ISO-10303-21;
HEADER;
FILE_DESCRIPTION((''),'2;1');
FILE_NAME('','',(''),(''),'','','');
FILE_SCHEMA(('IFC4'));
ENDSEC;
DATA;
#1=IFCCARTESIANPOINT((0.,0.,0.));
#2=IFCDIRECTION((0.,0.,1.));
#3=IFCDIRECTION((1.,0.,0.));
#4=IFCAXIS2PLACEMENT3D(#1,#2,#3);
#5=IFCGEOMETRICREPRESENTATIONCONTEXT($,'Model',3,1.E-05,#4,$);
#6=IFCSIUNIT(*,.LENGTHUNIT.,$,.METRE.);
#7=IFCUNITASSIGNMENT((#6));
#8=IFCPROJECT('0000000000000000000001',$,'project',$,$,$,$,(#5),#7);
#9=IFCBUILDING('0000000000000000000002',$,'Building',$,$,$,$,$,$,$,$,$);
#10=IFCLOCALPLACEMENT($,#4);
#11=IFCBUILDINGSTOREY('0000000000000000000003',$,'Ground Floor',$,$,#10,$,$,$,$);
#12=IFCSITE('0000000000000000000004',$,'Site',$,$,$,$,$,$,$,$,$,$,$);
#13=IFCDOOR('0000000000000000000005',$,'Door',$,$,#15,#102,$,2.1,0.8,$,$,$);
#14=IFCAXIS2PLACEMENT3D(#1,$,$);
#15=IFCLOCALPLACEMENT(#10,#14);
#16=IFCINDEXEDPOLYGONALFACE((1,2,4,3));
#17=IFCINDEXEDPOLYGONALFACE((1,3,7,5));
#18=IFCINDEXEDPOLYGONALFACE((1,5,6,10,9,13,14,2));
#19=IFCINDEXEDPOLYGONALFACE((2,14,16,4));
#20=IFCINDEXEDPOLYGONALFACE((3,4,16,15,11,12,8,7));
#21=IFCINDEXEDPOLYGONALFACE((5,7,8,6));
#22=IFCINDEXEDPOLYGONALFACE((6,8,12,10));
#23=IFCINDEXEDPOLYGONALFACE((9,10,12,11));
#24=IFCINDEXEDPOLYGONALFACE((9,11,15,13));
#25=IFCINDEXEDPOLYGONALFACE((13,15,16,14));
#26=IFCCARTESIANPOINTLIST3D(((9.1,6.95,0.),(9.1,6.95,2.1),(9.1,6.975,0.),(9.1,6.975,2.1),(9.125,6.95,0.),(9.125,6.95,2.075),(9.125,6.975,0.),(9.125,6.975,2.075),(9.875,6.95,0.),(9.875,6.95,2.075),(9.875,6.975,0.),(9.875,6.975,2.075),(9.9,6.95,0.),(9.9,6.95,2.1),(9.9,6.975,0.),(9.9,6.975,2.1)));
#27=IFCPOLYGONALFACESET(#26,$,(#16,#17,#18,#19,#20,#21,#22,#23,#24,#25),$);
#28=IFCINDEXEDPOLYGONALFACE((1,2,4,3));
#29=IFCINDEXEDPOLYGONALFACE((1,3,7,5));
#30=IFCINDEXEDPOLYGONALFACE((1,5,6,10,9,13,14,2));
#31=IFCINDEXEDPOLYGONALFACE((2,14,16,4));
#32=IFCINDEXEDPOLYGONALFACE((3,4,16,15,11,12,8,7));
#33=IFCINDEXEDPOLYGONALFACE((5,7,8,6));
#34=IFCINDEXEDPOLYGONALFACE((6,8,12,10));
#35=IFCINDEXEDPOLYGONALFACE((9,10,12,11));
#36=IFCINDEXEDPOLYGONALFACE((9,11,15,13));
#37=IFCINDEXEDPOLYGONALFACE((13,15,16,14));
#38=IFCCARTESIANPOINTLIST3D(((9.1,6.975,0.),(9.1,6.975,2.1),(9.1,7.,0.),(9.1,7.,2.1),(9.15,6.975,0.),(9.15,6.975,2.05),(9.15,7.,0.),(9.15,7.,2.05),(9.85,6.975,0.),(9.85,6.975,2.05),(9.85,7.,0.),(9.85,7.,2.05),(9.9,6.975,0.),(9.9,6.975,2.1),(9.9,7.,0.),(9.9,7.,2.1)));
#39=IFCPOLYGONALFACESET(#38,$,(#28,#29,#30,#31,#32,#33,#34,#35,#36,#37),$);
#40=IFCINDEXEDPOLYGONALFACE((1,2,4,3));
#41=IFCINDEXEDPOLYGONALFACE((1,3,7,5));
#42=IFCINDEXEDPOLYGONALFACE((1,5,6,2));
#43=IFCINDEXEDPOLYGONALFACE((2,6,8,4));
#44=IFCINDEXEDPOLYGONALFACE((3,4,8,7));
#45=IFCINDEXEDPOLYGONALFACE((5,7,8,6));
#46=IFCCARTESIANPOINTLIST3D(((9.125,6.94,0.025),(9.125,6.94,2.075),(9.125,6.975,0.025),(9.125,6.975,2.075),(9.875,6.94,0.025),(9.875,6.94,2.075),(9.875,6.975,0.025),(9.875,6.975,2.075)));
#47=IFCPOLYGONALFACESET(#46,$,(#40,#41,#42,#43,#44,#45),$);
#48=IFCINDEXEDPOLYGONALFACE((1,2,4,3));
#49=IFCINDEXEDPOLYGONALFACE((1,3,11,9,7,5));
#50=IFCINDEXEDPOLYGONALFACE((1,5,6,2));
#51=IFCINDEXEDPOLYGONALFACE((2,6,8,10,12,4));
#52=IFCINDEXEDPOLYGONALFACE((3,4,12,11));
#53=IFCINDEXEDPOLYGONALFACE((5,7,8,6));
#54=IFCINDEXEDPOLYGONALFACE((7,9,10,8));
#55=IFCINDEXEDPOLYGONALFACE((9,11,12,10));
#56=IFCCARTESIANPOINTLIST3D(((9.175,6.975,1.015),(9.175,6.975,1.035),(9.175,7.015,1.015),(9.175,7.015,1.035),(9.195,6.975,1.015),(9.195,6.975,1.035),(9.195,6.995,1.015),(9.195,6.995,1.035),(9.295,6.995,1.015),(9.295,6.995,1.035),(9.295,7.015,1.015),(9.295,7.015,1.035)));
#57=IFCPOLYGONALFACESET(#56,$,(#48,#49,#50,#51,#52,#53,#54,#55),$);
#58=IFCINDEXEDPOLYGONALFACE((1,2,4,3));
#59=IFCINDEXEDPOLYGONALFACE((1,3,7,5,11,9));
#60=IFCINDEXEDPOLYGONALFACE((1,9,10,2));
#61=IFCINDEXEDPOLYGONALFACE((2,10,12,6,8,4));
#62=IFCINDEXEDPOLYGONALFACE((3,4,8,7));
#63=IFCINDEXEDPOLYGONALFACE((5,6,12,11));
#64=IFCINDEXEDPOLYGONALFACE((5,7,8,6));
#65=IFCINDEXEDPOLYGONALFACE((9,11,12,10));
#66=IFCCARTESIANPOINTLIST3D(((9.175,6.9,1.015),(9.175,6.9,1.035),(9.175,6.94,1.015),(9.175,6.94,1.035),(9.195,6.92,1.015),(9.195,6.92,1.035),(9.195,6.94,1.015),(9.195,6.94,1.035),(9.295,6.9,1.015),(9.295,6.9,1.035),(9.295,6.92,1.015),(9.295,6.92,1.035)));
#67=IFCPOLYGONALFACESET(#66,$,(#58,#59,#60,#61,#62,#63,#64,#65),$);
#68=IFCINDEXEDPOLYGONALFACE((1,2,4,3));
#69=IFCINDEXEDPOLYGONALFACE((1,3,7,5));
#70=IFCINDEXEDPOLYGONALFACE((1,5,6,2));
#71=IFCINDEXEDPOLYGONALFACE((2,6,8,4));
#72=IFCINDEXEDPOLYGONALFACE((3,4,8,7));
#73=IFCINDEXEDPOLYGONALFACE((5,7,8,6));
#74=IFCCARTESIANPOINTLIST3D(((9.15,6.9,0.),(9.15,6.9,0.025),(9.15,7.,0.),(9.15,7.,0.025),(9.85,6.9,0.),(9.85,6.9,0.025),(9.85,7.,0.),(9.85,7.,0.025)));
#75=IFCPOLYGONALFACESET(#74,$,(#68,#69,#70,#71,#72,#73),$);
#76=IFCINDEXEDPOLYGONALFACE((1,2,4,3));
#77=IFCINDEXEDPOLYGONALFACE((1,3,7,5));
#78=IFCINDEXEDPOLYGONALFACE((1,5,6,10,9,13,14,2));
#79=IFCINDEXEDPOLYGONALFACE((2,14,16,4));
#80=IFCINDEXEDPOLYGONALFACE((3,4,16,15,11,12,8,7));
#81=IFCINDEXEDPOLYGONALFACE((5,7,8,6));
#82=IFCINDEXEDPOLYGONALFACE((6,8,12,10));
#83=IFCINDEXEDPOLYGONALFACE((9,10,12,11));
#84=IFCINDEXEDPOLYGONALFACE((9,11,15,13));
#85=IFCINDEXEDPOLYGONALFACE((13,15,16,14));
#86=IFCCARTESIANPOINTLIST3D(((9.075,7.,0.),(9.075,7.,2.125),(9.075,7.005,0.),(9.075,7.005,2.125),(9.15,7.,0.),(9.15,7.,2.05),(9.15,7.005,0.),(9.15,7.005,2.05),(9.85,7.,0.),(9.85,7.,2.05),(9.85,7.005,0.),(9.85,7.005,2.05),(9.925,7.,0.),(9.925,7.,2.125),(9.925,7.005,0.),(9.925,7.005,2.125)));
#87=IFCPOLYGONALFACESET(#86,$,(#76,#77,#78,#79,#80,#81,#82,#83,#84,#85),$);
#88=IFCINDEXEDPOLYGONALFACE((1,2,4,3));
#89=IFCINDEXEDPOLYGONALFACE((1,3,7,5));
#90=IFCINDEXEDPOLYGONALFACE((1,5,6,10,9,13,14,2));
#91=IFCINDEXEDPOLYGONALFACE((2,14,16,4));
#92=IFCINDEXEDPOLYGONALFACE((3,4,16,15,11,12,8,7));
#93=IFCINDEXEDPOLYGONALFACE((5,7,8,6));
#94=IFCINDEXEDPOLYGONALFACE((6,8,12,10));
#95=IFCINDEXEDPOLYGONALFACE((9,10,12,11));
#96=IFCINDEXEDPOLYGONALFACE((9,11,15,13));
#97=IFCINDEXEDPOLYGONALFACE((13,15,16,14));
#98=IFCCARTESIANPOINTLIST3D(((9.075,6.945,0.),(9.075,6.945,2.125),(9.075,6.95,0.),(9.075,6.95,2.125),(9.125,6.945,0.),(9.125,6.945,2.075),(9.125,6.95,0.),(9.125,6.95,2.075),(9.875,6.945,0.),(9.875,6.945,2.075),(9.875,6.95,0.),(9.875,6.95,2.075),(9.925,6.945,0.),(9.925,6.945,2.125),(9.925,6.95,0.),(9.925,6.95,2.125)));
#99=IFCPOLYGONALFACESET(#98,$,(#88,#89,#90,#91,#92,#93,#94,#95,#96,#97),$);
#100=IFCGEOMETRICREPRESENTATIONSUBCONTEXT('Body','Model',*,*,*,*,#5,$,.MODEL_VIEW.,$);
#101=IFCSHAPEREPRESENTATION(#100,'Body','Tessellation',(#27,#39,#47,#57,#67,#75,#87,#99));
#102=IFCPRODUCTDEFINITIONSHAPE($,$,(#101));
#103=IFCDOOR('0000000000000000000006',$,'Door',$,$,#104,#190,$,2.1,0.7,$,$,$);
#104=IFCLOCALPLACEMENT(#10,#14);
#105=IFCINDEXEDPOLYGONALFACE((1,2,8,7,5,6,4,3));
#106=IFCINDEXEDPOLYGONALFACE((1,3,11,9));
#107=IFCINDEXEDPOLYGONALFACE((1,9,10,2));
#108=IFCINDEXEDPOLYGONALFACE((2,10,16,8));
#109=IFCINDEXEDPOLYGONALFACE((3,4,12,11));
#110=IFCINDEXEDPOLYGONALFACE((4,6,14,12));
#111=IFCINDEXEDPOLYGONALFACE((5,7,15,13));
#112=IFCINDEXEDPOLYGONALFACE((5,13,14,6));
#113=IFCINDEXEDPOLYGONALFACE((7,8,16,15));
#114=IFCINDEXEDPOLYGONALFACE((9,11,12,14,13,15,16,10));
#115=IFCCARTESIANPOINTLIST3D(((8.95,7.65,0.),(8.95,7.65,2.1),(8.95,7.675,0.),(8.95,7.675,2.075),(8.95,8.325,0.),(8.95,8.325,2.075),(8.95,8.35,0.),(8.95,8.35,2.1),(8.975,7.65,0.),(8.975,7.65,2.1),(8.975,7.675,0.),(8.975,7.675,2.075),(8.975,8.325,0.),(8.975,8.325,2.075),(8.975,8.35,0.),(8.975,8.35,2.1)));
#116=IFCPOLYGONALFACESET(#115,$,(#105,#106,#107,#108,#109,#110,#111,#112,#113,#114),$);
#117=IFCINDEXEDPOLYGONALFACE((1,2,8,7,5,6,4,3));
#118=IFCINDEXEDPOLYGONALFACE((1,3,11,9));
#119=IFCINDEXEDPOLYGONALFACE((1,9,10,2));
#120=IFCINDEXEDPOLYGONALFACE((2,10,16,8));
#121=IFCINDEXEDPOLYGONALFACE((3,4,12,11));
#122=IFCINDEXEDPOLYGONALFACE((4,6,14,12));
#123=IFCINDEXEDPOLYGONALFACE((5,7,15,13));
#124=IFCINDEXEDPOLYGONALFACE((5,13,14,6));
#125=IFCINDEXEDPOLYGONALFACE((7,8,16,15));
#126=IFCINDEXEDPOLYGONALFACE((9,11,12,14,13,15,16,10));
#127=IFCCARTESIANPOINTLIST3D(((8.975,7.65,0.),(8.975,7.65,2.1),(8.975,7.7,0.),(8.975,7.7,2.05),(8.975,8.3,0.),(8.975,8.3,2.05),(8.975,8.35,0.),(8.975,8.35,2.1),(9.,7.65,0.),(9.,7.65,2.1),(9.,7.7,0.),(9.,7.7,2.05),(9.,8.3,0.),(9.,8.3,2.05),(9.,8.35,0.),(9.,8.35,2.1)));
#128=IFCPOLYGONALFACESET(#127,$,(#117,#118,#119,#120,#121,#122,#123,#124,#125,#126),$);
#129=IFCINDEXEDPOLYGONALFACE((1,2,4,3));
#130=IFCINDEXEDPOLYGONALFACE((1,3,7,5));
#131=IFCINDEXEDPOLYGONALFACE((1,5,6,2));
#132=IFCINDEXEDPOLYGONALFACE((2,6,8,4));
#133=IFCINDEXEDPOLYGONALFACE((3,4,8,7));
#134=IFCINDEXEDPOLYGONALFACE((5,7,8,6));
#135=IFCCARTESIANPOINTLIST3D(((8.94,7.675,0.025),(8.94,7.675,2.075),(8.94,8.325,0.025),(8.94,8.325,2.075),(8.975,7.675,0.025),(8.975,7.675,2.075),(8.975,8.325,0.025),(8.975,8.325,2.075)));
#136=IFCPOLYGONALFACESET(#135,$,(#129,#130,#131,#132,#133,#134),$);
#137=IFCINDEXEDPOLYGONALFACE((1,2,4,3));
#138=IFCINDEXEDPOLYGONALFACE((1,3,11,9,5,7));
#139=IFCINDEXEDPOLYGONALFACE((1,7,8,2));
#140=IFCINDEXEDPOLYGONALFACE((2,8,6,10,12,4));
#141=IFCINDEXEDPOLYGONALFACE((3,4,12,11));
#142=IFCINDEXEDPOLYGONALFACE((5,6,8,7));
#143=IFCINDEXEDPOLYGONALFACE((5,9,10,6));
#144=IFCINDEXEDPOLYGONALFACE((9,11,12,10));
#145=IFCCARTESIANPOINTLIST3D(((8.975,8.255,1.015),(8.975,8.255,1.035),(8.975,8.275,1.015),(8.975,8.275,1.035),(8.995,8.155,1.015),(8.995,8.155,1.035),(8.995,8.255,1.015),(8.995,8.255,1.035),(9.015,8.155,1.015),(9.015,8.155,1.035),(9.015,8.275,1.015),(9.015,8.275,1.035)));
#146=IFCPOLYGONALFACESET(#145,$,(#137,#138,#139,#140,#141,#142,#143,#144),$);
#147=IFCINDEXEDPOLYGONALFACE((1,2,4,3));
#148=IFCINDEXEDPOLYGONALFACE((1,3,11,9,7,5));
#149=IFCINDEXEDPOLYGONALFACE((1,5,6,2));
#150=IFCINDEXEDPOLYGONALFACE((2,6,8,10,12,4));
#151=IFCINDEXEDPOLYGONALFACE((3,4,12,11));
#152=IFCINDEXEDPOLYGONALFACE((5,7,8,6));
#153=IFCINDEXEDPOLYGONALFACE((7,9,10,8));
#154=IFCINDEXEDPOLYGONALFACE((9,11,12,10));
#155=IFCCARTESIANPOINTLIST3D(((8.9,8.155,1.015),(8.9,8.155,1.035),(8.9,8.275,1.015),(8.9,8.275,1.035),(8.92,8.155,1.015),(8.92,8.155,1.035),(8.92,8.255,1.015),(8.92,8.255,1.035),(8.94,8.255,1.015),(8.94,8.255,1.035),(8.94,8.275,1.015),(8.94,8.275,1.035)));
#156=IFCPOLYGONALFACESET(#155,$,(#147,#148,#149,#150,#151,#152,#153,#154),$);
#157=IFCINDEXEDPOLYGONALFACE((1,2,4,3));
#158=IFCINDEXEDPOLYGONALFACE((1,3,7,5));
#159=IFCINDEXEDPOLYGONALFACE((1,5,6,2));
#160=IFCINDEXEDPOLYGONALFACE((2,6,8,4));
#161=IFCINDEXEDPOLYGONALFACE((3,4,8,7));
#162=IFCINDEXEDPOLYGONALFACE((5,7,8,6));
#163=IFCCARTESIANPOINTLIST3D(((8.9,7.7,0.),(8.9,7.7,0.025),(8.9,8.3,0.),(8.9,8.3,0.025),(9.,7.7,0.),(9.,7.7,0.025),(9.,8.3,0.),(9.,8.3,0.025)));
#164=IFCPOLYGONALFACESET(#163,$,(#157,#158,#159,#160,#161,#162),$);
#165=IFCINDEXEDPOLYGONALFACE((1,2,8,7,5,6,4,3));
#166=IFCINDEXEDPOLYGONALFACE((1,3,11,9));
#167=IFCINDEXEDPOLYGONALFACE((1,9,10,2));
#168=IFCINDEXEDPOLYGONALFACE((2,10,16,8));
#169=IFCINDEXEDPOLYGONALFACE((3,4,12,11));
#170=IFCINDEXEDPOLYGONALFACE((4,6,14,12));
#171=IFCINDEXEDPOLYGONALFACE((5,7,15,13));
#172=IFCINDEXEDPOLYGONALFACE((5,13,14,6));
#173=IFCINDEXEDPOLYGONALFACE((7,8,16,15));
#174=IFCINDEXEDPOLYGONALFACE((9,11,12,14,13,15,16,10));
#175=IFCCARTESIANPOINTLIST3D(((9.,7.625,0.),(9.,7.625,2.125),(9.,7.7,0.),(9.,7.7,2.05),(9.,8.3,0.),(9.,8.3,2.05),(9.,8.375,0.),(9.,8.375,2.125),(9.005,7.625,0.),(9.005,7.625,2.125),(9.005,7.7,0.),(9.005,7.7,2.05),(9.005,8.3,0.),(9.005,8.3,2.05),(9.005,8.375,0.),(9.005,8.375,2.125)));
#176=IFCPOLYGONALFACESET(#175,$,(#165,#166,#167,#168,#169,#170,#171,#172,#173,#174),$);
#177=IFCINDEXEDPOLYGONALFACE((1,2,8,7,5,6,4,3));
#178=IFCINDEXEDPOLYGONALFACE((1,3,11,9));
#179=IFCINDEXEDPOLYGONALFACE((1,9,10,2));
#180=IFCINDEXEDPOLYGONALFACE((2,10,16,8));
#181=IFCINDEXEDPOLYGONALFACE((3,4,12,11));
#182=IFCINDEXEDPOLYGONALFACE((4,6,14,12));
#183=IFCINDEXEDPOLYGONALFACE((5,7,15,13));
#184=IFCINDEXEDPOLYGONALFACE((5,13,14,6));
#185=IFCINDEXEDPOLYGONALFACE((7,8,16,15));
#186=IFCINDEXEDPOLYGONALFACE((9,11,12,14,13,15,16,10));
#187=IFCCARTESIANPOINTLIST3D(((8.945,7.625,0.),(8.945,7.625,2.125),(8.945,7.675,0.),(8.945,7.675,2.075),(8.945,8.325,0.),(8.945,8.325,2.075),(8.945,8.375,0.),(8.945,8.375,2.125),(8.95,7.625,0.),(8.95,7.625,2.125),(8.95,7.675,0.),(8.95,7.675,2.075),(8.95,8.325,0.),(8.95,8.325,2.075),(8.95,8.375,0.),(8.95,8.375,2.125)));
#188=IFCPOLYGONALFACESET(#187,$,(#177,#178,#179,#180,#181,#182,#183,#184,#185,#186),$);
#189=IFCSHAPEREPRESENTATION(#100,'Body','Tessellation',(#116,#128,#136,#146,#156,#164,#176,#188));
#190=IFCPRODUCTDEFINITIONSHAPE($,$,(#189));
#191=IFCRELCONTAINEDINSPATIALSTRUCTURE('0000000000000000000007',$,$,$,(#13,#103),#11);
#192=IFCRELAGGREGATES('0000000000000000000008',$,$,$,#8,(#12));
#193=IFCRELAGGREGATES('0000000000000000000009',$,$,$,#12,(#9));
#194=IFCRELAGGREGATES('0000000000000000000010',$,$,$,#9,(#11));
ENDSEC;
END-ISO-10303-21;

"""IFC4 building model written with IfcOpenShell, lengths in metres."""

from ifc_helpers import new_model, si_unit, frame, origin_with_axes, place, context, subcontext, project, spatial, line, indexed_curve, outline, extrude, element, save


model = new_model("IFC4")

# Units and contexts
model_context = context("Model", 3, precision=1e-05, world=origin_with_axes())
body_context = subcontext(model_context, "Body", "Model", "MODEL_VIEW")
ifc_project = project(units=[si_unit("LENGTHUNIT", "METRE")], contexts=[model_context])

# Site, building, storey
site = spatial("IfcSite", under=ifc_project, Name="Site")
building = spatial("IfcBuilding", under=site, Name="Building")
storey_placement = place(None, origin_with_axes())
storey = spatial("IfcBuildingStorey", under=building, at=storey_placement, Name="Ground Floor")

# Doors
door_1_placement = place(storey_placement, frame((9.9, 7.0, 0.0), z_axis=(0.0, 0.0, 1.0), x_axis=(-1.0, 0.0, 0.0)))
element("IfcDoor", 1, at=door_1_placement, inside=storey, Name="Door", OverallHeight=2.1, OverallWidth=0.8, context=body_context, shape_type="SweptSolid", body=[
    extrude(outline(indexed_curve([(0.0, 0.0), (0.0, 2.1), (0.8, 2.1), (0.8, 0.0), (0.775, 0.0), (0.775, 2.075), (0.025, 2.075), (0.025, 0.0)], segments=[line(1, 2, 3, 4, 5, 6, 7, 8, 1)])), frame((0.0, 0.025, 0.0), z_axis=(0.0, -1.0, 0.0), x_axis=(1.0, 0.0, 0.0)), (0.0, 0.0, -1.0), 0.025),
    extrude(outline(indexed_curve([(0.0, 0.0), (0.0, 2.1), (0.8, 2.1), (0.8, 0.0), (0.75, 0.0), (0.75, 2.05), (0.05, 2.05), (0.05, 0.0)], segments=[line(1, 2, 3, 4, 5, 6, 7, 8, 1)])), frame((0.0, 0.0, 0.0), z_axis=(0.0, -1.0, 0.0), x_axis=(1.0, 0.0, 0.0)), (0.0, 0.0, -1.0), 0.025),
    extrude(outline(indexed_curve([(0.0, 0.0), (0.75, 0.0), (0.75, 0.035), (0.0, 0.035)], segments=[line(1, 2, 3, 4, 1)])), frame((0.025, 0.025, 0.025), z_axis=(0.0, 0.0, 1.0), x_axis=(1.0, 0.0, 0.0)), (0.0, 0.0, 1.0), 2.05),
    extrude(outline(indexed_curve([(0.0, 0.0), (0.0, -0.04), (-0.12, -0.04), (-0.12, -0.02), (-0.02, -0.02), (-0.02, 0.0)], segments=[line(1, 2, 3, 4, 5, 6, 1)])), frame((0.725, 0.025, 1.015), z_axis=(0.0, 0.0, 1.0), x_axis=(1.0, 0.0, 0.0)), (0.0, 0.0, 1.0), 0.02),
    extrude(outline(indexed_curve([(0.0, 0.0), (0.0, 0.04), (-0.12, 0.04), (-0.12, 0.02), (-0.02, 0.02), (-0.02, 0.0)], segments=[line(1, 2, 3, 4, 5, 6, 1)])), frame((0.725, 0.06, 1.015), z_axis=(0.0, 0.0, 1.0), x_axis=(1.0, 0.0, 0.0)), (0.0, 0.0, 1.0), 0.02),
    extrude(outline(indexed_curve([(0.0, 0.0), (0.7, 0.0), (0.7, 0.1), (0.0, 0.1)], segments=[line(1, 2, 3, 4, 1)])), frame((0.05, 0.0, 0.0), z_axis=(0.0, 0.0, 1.0), x_axis=(1.0, 0.0, 0.0)), (0.0, 0.0, 1.0), 0.025),
    extrude(outline(indexed_curve([(0.0, 0.0), (0.0, 2.125), (0.85, 2.125), (0.85, 0.0), (0.775, 0.0), (0.775, 2.05), (0.075, 2.05), (0.075, 0.0)], segments=[line(1, 2, 3, 4, 5, 6, 7, 8, 1)])), frame((-0.025, -0.005, 0.0), z_axis=(0.0, -1.0, 0.0), x_axis=(1.0, 0.0, 0.0)), (0.0, 0.0, -1.0), 0.005),
    extrude(outline(indexed_curve([(0.0, 0.0), (0.0, 2.125), (0.85, 2.125), (0.85, 0.0), (0.8, 0.0), (0.8, 2.075), (0.05, 2.075), (0.05, 0.0)], segments=[line(1, 2, 3, 4, 5, 6, 7, 8, 1)])), frame((-0.025, 0.05, 0.0), z_axis=(0.0, -1.0, 0.0), x_axis=(1.0, 0.0, 0.0)), (0.0, 0.0, -1.0), 0.005),
])
door_2_placement = place(storey_placement, frame((9.0, 7.65, 0.0), z_axis=(0.0, 0.0, 1.0), x_axis=(0.0, 1.0, 0.0)))
element("IfcDoor", 2, at=door_2_placement, inside=storey, Name="Door", OverallHeight=2.1, OverallWidth=0.7, context=body_context, shape_type="SweptSolid", body=[
    extrude(outline(indexed_curve([(0.0, 0.0), (0.0, 2.1), (0.7, 2.1), (0.7, 0.0), (0.675, 0.0), (0.675, 2.075), (0.025, 2.075), (0.025, 0.0)], segments=[line(1, 2, 3, 4, 5, 6, 7, 8, 1)])), frame((0.0, 0.025, 0.0), z_axis=(0.0, -1.0, 0.0), x_axis=(1.0, 0.0, 0.0)), (0.0, 0.0, -1.0), 0.025),
    extrude(outline(indexed_curve([(0.0, 0.0), (0.0, 2.1), (0.7, 2.1), (0.7, 0.0), (0.65, 0.0), (0.65, 2.05), (0.05, 2.05), (0.05, 0.0)], segments=[line(1, 2, 3, 4, 5, 6, 7, 8, 1)])), frame((0.0, 0.0, 0.0), z_axis=(0.0, -1.0, 0.0), x_axis=(1.0, 0.0, 0.0)), (0.0, 0.0, -1.0), 0.025),
    extrude(outline(indexed_curve([(0.0, 0.0), (0.65, 0.0), (0.65, 0.035), (0.0, 0.035)], segments=[line(1, 2, 3, 4, 1)])), frame((0.025, 0.025, 0.025), z_axis=(0.0, 0.0, 1.0), x_axis=(1.0, 0.0, 0.0)), (0.0, 0.0, 1.0), 2.05),
    extrude(outline(indexed_curve([(0.0, 0.0), (0.0, -0.04), (-0.12, -0.04), (-0.12, -0.02), (-0.02, -0.02), (-0.02, 0.0)], segments=[line(1, 2, 3, 4, 5, 6, 1)])), frame((0.625, 0.025, 1.015), z_axis=(0.0, 0.0, 1.0), x_axis=(1.0, 0.0, 0.0)), (0.0, 0.0, 1.0), 0.02),
    extrude(outline(indexed_curve([(0.0, 0.0), (0.0, 0.04), (-0.12, 0.04), (-0.12, 0.02), (-0.02, 0.02), (-0.02, 0.0)], segments=[line(1, 2, 3, 4, 5, 6, 1)])), frame((0.625, 0.06, 1.015), z_axis=(0.0, 0.0, 1.0), x_axis=(1.0, 0.0, 0.0)), (0.0, 0.0, 1.0), 0.02),
    extrude(outline(indexed_curve([(0.0, 0.0), (0.6, 0.0), (0.6, 0.1), (0.0, 0.1)], segments=[line(1, 2, 3, 4, 1)])), frame((0.05, 0.0, 0.0), z_axis=(0.0, 0.0, 1.0), x_axis=(1.0, 0.0, 0.0)), (0.0, 0.0, 1.0), 0.025),
    extrude(outline(indexed_curve([(0.0, 0.0), (0.0, 2.125), (0.75, 2.125), (0.75, 0.0), (0.675, 0.0), (0.675, 2.05), (0.075, 2.05), (0.075, 0.0)], segments=[line(1, 2, 3, 4, 5, 6, 7, 8, 1)])), frame((-0.025, -0.005, 0.0), z_axis=(0.0, -1.0, 0.0), x_axis=(1.0, 0.0, 0.0)), (0.0, 0.0, -1.0), 0.005),
    extrude(outline(indexed_curve([(0.0, 0.0), (0.0, 2.125), (0.75, 2.125), (0.75, 0.0), (0.7, 0.0), (0.7, 2.075), (0.05, 2.075), (0.05, 0.0)], segments=[line(1, 2, 3, 4, 5, 6, 7, 8, 1)])), frame((-0.025, 0.05, 0.0), z_axis=(0.0, -1.0, 0.0), x_axis=(1.0, 0.0, 0.0)), (0.0, 0.0, -1.0), 0.005),
])

save(model, "model.ifc")
